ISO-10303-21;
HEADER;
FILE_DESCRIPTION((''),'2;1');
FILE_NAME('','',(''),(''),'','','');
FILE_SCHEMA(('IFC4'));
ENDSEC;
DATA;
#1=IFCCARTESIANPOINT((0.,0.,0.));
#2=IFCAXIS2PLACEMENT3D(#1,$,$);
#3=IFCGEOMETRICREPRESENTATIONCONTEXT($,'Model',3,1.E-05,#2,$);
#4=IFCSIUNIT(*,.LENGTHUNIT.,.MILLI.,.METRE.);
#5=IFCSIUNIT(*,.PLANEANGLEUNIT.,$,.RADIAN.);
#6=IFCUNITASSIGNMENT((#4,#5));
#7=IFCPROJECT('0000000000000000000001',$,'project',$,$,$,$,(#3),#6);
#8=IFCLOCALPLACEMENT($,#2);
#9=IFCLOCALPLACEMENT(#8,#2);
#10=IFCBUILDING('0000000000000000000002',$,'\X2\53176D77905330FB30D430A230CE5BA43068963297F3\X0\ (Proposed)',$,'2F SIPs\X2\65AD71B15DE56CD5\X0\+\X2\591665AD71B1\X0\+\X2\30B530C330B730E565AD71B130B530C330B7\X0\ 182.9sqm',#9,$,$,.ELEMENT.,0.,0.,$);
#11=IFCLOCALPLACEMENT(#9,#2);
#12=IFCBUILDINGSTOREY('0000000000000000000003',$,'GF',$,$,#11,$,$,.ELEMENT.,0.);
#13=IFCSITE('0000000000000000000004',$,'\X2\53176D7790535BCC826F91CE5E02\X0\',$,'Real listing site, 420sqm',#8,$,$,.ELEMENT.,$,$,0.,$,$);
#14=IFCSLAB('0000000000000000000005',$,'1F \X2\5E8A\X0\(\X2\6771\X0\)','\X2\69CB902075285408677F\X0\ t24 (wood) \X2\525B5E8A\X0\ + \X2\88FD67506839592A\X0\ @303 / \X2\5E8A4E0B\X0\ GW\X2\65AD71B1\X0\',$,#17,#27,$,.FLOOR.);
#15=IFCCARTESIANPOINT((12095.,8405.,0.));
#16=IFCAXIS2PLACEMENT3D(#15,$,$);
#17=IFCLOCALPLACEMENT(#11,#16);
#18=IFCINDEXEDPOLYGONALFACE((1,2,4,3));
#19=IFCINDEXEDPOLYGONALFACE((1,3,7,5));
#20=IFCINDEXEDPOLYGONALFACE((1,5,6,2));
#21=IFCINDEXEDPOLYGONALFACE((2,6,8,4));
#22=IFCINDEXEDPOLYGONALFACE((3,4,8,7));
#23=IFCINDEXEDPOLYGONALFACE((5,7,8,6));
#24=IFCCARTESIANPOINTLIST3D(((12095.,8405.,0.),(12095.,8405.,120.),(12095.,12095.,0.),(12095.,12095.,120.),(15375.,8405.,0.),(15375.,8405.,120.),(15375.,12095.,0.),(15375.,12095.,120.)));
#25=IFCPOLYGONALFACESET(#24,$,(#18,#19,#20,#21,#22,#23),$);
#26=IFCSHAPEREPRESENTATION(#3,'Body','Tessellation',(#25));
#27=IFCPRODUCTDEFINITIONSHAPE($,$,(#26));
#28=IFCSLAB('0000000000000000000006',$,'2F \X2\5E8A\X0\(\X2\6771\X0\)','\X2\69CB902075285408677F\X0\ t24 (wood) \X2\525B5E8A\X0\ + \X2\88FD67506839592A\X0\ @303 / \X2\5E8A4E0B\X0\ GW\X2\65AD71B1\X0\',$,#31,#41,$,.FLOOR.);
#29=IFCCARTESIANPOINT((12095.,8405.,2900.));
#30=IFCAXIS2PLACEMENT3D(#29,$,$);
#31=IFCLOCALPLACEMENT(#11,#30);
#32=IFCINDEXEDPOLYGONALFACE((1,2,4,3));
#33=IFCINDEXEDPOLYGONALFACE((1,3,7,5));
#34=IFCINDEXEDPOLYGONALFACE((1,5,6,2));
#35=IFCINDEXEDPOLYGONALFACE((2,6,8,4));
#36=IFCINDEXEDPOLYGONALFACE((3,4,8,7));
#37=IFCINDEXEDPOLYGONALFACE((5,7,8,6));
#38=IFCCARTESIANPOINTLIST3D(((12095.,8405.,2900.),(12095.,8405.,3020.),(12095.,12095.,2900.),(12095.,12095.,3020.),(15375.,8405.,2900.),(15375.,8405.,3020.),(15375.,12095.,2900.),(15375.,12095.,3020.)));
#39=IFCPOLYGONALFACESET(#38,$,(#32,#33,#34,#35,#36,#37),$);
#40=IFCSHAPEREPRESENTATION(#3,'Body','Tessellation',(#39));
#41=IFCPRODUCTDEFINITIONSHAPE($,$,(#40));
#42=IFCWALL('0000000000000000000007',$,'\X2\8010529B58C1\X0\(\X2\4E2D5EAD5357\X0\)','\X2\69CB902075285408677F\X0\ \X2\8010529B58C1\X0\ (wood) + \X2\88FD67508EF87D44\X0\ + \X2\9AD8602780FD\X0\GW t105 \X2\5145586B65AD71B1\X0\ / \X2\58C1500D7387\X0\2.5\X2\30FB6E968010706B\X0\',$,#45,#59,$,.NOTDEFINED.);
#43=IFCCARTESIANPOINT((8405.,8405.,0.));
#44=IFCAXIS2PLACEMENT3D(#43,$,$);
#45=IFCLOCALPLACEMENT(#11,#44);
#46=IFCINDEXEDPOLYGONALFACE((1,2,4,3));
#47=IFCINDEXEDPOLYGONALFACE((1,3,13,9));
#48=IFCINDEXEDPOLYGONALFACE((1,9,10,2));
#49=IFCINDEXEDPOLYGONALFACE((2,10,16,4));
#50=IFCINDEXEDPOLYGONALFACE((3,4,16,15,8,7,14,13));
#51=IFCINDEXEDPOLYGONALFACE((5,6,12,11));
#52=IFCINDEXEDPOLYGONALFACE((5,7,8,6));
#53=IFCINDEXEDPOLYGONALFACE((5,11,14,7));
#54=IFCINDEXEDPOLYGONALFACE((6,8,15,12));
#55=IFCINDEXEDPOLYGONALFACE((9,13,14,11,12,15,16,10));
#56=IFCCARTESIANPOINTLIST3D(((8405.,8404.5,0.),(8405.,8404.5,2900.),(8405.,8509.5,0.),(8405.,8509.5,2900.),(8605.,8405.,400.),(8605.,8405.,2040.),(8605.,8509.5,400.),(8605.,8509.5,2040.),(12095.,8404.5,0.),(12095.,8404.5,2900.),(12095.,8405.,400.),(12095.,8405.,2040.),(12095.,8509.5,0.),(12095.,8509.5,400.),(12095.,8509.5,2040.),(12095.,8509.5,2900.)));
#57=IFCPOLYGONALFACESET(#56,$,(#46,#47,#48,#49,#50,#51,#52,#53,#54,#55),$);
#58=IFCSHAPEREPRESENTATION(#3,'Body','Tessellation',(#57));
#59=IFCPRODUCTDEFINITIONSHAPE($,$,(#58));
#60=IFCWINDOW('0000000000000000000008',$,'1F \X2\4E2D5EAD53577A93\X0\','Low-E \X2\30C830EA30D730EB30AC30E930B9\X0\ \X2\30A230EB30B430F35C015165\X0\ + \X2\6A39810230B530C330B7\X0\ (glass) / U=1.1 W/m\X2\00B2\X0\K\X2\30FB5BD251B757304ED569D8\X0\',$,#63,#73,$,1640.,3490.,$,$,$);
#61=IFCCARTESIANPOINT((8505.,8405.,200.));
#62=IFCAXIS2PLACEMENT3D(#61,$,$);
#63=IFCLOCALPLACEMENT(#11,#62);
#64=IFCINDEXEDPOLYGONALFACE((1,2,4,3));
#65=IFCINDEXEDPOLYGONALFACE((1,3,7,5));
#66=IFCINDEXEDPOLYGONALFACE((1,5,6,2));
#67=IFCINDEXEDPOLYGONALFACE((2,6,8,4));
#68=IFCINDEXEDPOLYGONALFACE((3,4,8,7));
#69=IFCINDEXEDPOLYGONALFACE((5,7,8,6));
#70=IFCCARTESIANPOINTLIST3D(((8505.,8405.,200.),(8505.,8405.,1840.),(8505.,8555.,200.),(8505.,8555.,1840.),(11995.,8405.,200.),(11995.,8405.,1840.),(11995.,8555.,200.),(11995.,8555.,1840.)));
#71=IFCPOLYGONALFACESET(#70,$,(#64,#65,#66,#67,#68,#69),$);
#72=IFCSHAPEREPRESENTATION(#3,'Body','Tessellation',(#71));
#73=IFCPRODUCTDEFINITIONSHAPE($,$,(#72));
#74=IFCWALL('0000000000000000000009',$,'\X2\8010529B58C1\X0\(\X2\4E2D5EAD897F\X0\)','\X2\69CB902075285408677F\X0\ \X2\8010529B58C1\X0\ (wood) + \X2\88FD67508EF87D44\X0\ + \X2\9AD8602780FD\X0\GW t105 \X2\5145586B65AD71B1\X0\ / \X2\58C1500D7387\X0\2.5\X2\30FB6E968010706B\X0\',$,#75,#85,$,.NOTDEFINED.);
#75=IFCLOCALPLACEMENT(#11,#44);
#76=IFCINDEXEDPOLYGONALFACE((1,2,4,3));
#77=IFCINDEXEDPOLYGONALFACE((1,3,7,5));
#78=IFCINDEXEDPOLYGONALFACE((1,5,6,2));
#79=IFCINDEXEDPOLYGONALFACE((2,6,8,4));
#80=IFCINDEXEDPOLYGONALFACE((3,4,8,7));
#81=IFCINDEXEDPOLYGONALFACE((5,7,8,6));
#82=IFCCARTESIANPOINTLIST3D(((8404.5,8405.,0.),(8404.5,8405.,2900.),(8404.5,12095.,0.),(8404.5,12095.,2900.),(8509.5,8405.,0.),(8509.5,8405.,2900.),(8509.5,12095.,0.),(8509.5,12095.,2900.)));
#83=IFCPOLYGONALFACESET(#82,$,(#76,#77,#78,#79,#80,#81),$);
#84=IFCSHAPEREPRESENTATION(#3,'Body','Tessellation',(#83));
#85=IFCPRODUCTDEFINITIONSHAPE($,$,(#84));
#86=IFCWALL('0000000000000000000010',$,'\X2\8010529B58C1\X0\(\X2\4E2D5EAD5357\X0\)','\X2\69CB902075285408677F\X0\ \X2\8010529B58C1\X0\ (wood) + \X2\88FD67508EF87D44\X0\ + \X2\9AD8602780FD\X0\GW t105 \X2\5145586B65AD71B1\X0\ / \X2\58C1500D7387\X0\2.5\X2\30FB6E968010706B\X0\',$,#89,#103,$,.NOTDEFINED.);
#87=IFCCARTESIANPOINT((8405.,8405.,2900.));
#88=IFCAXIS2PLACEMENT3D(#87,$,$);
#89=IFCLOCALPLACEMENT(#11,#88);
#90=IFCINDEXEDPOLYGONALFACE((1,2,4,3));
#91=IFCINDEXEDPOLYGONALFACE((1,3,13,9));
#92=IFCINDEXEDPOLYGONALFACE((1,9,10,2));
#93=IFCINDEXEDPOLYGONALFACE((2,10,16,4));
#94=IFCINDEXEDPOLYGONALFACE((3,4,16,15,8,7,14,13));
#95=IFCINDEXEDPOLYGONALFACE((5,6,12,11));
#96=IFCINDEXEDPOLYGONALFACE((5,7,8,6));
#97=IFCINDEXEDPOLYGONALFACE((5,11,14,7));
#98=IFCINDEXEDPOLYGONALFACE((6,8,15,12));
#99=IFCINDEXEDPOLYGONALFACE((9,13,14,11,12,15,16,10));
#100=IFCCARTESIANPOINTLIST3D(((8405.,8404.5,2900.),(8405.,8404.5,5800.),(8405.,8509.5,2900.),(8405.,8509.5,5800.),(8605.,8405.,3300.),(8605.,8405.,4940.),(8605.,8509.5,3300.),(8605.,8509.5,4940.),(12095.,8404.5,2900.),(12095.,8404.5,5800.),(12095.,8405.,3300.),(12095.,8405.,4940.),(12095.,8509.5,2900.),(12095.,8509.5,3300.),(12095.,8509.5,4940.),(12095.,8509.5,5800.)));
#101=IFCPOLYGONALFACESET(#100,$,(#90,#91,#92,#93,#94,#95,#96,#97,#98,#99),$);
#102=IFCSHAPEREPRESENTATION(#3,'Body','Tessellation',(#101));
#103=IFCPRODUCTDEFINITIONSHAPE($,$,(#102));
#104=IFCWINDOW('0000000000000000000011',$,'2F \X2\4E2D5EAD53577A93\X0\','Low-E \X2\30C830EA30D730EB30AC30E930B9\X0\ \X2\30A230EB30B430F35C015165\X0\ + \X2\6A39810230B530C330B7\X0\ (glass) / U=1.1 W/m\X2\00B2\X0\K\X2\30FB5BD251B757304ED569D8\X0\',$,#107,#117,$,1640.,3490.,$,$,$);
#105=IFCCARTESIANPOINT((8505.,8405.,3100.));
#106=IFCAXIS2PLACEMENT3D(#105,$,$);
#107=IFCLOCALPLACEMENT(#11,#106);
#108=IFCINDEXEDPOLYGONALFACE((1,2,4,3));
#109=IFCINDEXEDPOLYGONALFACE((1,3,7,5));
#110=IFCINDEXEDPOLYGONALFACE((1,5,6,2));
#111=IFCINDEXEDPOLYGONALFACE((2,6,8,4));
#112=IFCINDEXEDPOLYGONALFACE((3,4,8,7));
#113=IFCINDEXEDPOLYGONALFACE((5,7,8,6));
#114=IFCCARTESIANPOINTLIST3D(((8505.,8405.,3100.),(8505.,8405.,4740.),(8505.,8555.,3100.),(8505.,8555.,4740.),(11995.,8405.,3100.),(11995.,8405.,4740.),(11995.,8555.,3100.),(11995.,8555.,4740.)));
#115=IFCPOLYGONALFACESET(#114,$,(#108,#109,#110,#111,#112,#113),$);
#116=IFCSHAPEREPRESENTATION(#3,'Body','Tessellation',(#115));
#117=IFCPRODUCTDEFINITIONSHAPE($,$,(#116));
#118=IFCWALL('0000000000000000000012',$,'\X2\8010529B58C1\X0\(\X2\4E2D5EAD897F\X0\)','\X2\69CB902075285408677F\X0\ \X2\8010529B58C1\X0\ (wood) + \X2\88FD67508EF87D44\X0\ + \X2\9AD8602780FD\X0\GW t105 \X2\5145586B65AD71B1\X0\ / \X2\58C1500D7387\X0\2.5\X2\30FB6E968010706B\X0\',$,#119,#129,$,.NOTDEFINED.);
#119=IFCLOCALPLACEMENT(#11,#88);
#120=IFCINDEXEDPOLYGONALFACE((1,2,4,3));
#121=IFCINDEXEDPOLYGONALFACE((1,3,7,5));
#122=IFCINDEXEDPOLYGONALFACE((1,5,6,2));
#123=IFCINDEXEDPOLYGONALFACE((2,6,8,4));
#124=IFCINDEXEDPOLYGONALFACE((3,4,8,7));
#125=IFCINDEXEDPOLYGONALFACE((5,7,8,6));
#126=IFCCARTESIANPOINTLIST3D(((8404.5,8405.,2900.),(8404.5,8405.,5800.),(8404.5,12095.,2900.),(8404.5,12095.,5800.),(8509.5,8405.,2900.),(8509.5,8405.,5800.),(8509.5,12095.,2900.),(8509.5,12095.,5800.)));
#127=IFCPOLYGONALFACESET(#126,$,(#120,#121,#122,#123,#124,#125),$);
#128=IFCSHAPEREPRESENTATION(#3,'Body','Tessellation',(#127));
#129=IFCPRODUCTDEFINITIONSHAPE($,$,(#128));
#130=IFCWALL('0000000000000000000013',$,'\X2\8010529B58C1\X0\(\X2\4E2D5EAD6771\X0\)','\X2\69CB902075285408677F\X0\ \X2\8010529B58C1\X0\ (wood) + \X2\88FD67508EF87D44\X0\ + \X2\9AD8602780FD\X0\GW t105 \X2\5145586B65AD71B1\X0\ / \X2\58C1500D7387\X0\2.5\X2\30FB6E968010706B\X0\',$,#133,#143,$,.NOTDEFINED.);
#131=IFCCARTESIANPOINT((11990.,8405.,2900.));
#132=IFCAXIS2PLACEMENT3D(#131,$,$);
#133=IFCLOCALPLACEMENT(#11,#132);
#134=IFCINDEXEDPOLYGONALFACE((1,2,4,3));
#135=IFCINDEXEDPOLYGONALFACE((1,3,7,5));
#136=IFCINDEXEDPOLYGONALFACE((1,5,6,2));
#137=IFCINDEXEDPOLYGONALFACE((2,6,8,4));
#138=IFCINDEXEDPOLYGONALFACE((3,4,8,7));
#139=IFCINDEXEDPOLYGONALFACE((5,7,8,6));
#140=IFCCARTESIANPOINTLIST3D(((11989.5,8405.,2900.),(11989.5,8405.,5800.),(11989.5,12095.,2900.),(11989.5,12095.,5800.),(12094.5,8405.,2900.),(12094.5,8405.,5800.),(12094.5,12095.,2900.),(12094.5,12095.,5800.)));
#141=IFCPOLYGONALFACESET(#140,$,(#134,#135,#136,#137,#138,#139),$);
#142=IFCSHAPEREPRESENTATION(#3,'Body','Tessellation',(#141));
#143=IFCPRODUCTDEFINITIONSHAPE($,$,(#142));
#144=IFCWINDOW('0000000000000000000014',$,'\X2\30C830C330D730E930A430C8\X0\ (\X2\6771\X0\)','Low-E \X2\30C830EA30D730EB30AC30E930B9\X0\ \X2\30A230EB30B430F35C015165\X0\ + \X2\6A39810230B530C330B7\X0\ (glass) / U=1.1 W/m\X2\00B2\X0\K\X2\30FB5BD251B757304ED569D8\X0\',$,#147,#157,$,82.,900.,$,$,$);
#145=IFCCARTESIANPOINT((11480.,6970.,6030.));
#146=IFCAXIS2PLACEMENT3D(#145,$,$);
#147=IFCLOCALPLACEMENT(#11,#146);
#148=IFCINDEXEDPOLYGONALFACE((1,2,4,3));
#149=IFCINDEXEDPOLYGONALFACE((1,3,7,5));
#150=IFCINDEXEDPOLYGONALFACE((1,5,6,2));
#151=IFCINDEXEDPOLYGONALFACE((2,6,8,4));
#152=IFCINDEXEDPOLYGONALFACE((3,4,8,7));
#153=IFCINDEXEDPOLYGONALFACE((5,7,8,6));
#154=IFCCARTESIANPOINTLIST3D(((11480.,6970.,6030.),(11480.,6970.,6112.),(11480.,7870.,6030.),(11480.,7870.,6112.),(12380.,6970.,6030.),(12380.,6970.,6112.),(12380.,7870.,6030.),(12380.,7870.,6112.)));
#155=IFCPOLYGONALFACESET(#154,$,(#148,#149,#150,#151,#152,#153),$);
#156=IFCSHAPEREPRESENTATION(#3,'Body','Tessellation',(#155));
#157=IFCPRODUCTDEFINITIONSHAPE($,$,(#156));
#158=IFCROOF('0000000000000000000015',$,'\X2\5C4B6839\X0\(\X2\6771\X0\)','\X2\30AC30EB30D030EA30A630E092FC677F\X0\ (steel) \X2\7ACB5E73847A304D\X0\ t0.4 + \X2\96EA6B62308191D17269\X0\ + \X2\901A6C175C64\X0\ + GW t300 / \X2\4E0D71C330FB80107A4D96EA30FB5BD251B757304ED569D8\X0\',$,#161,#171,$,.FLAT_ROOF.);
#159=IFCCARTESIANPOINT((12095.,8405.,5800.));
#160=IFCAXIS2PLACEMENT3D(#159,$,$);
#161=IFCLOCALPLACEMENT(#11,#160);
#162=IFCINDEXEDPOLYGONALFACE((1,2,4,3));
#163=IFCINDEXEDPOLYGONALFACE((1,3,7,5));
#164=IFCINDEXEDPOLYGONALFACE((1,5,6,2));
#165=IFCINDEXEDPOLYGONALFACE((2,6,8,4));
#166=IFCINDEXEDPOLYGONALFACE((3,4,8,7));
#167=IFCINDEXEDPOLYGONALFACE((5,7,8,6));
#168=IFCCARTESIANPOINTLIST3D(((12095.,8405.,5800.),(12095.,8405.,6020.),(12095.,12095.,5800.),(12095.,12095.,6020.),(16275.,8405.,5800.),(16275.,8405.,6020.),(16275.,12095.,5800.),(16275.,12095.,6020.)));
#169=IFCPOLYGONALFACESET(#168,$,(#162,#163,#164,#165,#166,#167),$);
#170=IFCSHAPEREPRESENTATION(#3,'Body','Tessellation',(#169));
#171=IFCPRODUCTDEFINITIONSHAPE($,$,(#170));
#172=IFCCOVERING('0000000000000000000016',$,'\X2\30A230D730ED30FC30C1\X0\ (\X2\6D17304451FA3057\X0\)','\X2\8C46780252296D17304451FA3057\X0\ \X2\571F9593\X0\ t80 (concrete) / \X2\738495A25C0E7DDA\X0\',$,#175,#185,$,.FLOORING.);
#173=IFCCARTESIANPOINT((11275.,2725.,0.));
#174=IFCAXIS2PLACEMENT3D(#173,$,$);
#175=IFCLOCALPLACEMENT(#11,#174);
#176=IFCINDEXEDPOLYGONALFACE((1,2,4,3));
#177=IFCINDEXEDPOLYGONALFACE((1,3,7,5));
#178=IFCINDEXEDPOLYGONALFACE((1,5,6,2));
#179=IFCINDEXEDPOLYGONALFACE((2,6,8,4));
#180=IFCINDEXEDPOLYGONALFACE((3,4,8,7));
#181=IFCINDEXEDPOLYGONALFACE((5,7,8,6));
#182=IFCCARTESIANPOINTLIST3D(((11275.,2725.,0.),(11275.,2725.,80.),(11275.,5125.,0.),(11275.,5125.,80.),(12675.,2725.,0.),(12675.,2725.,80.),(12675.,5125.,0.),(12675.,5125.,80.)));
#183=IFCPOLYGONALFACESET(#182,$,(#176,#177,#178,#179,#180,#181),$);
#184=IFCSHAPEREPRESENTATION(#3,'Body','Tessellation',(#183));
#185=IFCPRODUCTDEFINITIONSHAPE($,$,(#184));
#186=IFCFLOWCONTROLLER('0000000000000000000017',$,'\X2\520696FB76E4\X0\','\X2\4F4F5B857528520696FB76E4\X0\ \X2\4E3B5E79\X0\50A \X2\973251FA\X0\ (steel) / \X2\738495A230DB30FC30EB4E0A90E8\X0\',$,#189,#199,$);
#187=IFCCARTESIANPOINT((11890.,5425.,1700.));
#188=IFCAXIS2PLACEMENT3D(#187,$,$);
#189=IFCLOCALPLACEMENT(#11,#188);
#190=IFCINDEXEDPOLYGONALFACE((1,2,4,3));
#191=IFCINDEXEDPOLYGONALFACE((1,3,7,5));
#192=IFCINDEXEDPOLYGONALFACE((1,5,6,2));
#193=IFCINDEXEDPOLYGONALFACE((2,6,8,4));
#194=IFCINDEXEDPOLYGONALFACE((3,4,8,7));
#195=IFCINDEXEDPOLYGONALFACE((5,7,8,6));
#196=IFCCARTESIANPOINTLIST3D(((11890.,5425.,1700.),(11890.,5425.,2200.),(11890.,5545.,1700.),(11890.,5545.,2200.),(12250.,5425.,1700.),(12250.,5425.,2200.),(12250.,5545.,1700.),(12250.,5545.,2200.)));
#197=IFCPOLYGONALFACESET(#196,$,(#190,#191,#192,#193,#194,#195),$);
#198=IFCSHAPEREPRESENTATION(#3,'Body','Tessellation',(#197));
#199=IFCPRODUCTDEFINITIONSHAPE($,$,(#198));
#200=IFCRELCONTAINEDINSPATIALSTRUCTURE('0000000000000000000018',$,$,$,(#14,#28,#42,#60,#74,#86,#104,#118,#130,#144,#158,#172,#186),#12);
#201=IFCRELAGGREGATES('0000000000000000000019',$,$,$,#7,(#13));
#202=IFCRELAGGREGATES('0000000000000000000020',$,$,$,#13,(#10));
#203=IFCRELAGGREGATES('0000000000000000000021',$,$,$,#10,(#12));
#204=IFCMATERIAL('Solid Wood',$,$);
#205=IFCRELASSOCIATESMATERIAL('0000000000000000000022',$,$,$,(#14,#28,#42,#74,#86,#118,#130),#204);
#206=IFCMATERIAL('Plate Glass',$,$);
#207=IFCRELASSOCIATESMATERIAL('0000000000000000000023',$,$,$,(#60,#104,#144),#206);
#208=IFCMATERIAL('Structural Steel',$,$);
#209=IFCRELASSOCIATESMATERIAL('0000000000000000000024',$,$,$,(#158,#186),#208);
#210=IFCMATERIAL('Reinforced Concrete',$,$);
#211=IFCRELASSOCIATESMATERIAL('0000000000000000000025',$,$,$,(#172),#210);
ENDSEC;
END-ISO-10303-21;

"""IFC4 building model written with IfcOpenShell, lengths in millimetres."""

from ifc_helpers import new_model, si_unit, frame, frame_2d, origin, place, context, project, spatial, rectangle, extrude, material, element, fill, save


model = new_model("IFC4")

# Units and contexts
model_context = context("Model", 3, precision=1e-05, world=origin())
ifc_project = project(units=[si_unit("LENGTHUNIT", "METRE", prefix="MILLI"), si_unit("PLANEANGLEUNIT", "RADIAN")], contexts=[model_context])

# Site, building, storey
site_placement = place(None, origin())
site = spatial("IfcSite", under=ifc_project, at=site_placement, Name="北海道富良野市", ObjectType="Real listing site, 420sqm", CompositionType="ELEMENT", RefElevation=0.0)
building_placement = place(site_placement, origin())
building = spatial("IfcBuilding", under=site, at=building_placement, Name="北海道・ピアノ室と防音 (Proposed)", ObjectType="2F SIPs断熱工法+外断熱+サッシュ断熱サッシ 182.9sqm", CompositionType="ELEMENT", ElevationOfRefHeight=0.0, ElevationOfTerrain=0.0)
storey_placement = place(building_placement, origin())
storey = spatial("IfcBuildingStorey", under=building, at=storey_placement, Name="GF", CompositionType="ELEMENT", Elevation=0.0)

# Shared definitions
ifc_material_1 = material(Name="Solid Wood")

# Slabs
slab_1_placement = place(storey_placement, frame((12095.0, 8405.0, 0.0)))
element("IfcSlab", 1, at=slab_1_placement, inside=storey, material=ifc_material_1, Name="1F 床(東)", Description="構造用合板 t24 (wood) 剛床 + 製材根太 @303 / 床下 GW断熱", PredefinedType="FLOOR", context=model_context, shape_type="SweptSolid", body=[
    extrude(rectangle(XDim=3280.0, YDim=3690.0, at=frame_2d((1640.0, 1845.0))), frame((12095.0, 8405.0, 0.0)), (0.0, 0.0, 1.0), 120.0),
])
slab_2_placement = place(storey_placement, frame((12095.0, 8405.0, 2900.0)))
element("IfcSlab", 2, at=slab_2_placement, inside=storey, material=ifc_material_1, Name="2F 床(東)", Description="構造用合板 t24 (wood) 剛床 + 製材根太 @303 / 床下 GW断熱", PredefinedType="FLOOR", context=model_context, shape_type="SweptSolid", body=[
    extrude(rectangle(XDim=3280.0, YDim=3690.0, at=frame_2d((1640.0, 1845.0))), frame((12095.0, 8405.0, 2900.0)), (0.0, 0.0, 1.0), 120.0),
])

# Wall, opening, window
wall_1_placement = place(storey_placement, frame((8405.0, 8405.0, 0.0)))
wall_1 = element("IfcWall", 3, at=wall_1_placement, inside=storey, material=ifc_material_1, Name="耐力壁(中庭南)", Description="構造用合板 耐力壁 (wood) + 製材軸組 + 高性能GW t105 充填断熱 / 壁倍率2.5・準耐火", PredefinedType="NOTDEFINED", context=model_context, shape_type="SweptSolid", body=[
    extrude(rectangle(XDim=3690.0, YDim=105.0, at=frame_2d((1845.0, 52.0))), frame((8405.0, 8405.0, 0.0)), (0.0, 0.0, 1.0), 2900.0),
])
opening_1_placement = place(storey_placement, frame((8505.0, 8405.0, 200.0)))
opening_1 = element("IfcOpeningElement", 4, at=opening_1_placement, cuts=wall_1, PredefinedType="NOTDEFINED", context=model_context, shape_type="SweptSolid", body=[
    extrude(rectangle(XDim=3490.0, YDim=150.0, at=frame_2d((1745.0, 75.0))), frame((8505.0, 8405.0, 200.0)), (0.0, 0.0, 1.0), 1640.0),
])
ifc_material_2 = material(Name="Plate Glass")
window_1_placement = place(storey_placement, frame((8505.0, 8405.0, 200.0)))
window_1 = element("IfcWindow", 5, at=window_1_placement, inside=storey, material=ifc_material_2, Name="1F 中庭南窓", Description="Low-E トリプルガラス アルゴン封入 + 樹脂サッシ (glass) / U=1.1 W/m²K・寒冷地仕様", OverallHeight=1640.0, OverallWidth=3490.0, context=model_context, shape_type="SweptSolid", body=[
    extrude(rectangle(XDim=3490.0, YDim=150.0, at=frame_2d((1745.0, 75.0))), frame((8505.0, 8405.0, 200.0)), (0.0, 0.0, 1.0), 1640.0),
])
fill(opening_1, window_1)

# Wall
wall_2_placement = place(storey_placement, frame((8405.0, 8405.0, 0.0)))
element("IfcWall", 6, at=wall_2_placement, inside=storey, material=ifc_material_1, Name="耐力壁(中庭西)", Description="構造用合板 耐力壁 (wood) + 製材軸組 + 高性能GW t105 充填断熱 / 壁倍率2.5・準耐火", PredefinedType="NOTDEFINED", context=model_context, shape_type="SweptSolid", body=[
    extrude(rectangle(XDim=105.0, YDim=3690.0, at=frame_2d((52.0, 1845.0))), frame((8405.0, 8405.0, 0.0)), (0.0, 0.0, 1.0), 2900.0),
])

# Wall, opening, window
wall_3_placement = place(storey_placement, frame((8405.0, 8405.0, 2900.0)))
wall_3 = element("IfcWall", 7, at=wall_3_placement, inside=storey, material=ifc_material_1, Name="耐力壁(中庭南)", Description="構造用合板 耐力壁 (wood) + 製材軸組 + 高性能GW t105 充填断熱 / 壁倍率2.5・準耐火", PredefinedType="NOTDEFINED", context=model_context, shape_type="SweptSolid", body=[
    extrude(rectangle(XDim=3690.0, YDim=105.0, at=frame_2d((1845.0, 52.0))), frame((8405.0, 8405.0, 2900.0)), (0.0, 0.0, 1.0), 2900.0),
])
opening_2_placement = place(storey_placement, frame((8505.0, 8405.0, 3100.0)))
opening_2 = element("IfcOpeningElement", 8, at=opening_2_placement, cuts=wall_3, PredefinedType="NOTDEFINED", context=model_context, shape_type="SweptSolid", body=[
    extrude(rectangle(XDim=3490.0, YDim=150.0, at=frame_2d((1745.0, 75.0))), frame((8505.0, 8405.0, 3100.0)), (0.0, 0.0, 1.0), 1640.0),
])
window_2_placement = place(storey_placement, frame((8505.0, 8405.0, 3100.0)))
window_2 = element("IfcWindow", 9, at=window_2_placement, inside=storey, material=ifc_material_2, Name="2F 中庭南窓", Description="Low-E トリプルガラス アルゴン封入 + 樹脂サッシ (glass) / U=1.1 W/m²K・寒冷地仕様", OverallHeight=1640.0, OverallWidth=3490.0, context=model_context, shape_type="SweptSolid", body=[
    extrude(rectangle(XDim=3490.0, YDim=150.0, at=frame_2d((1745.0, 75.0))), frame((8505.0, 8405.0, 3100.0)), (0.0, 0.0, 1.0), 1640.0),
])
fill(opening_2, window_2)

# Walls
wall_4_placement = place(storey_placement, frame((8405.0, 8405.0, 2900.0)))
element("IfcWall", 10, at=wall_4_placement, inside=storey, material=ifc_material_1, Name="耐力壁(中庭西)", Description="構造用合板 耐力壁 (wood) + 製材軸組 + 高性能GW t105 充填断熱 / 壁倍率2.5・準耐火", PredefinedType="NOTDEFINED", context=model_context, shape_type="SweptSolid", body=[
    extrude(rectangle(XDim=105.0, YDim=3690.0, at=frame_2d((52.0, 1845.0))), frame((8405.0, 8405.0, 2900.0)), (0.0, 0.0, 1.0), 2900.0),
])
wall_5_placement = place(storey_placement, frame((11990.0, 8405.0, 2900.0)))
element("IfcWall", 11, at=wall_5_placement, inside=storey, material=ifc_material_1, Name="耐力壁(中庭東)", Description="構造用合板 耐力壁 (wood) + 製材軸組 + 高性能GW t105 充填断熱 / 壁倍率2.5・準耐火", PredefinedType="NOTDEFINED", context=model_context, shape_type="SweptSolid", body=[
    extrude(rectangle(XDim=105.0, YDim=3690.0, at=frame_2d((52.0, 1845.0))), frame((11990.0, 8405.0, 2900.0)), (0.0, 0.0, 1.0), 2900.0),
])

# Window
window_3_placement = place(storey_placement, frame((11480.0, 6970.0, 6030.0)))
element("IfcWindow", 12, at=window_3_placement, inside=storey, material=ifc_material_2, Name="トップライト (東)", Description="Low-E トリプルガラス アルゴン封入 + 樹脂サッシ (glass) / U=1.1 W/m²K・寒冷地仕様", OverallHeight=82.0, OverallWidth=900.0, context=model_context, shape_type="SweptSolid", body=[
    extrude(rectangle(XDim=900.0, YDim=900.0, at=frame_2d((450.0, 450.0))), frame((11480.0, 6970.0, 6030.0)), (0.0, 0.0, 1.0), 82.0),
])

# Roof
ifc_material_3 = material(Name="Structural Steel")
for number, where, name in (
    (13, (12095.0, 8405.0, 5800.0), "屋根(東)"),
):
    element("IfcRoof", number, at=place(storey_placement, frame(where)), inside=storey, material=ifc_material_3, Name=name, Description="ガルバリウム鋼板 (steel) 立平葺き t0.4 + 雪止め金物 + 通気層 + GW t300 / 不燃・耐積雪・寒冷地仕様", PredefinedType="FLAT_ROOF", context=model_context, shape_type="SweptSolid", body=[
        extrude(rectangle(XDim=4180.0, YDim=3690.0, at=frame_2d((2090.0, 1845.0))), frame((12095.0, 8405.0, 5800.0)), (0.0, 0.0, 1.0), 220.0),
    ])

# Covering
ifc_material_4 = material(Name="Reinforced Concrete")
covering_placement = place(storey_placement, frame((11275.0, 2725.0, 0.0)))
element("IfcCovering", 14, at=covering_placement, inside=storey, material=ifc_material_4, Name="アプローチ (洗い出し)", Description="豆砂利洗い出し 土間 t80 (concrete) / 玄関導線", PredefinedType="FLOORING", context=model_context, shape_type="SweptSolid", body=[
    extrude(rectangle(XDim=1400.0, YDim=2400.0, at=frame_2d((700.0, 1200.0))), frame((11275.0, 2725.0, 0.0)), (0.0, 0.0, 1.0), 80.0),
])

# Flow controller
flow_controller_placement = place(storey_placement, frame((11890.0, 5425.0, 1700.0)))
element("IfcFlowController", 15, at=flow_controller_placement, inside=storey, material=ifc_material_3, Name="分電盤", Description="住宅用分電盤 主幹50A 露出 (steel) / 玄関ホール上部", context=model_context, shape_type="SweptSolid", body=[
    extrude(rectangle(XDim=360.0, YDim=120.0, at=frame_2d((180.0, 60.0))), frame((11890.0, 5425.0, 1700.0)), (0.0, 0.0, 1.0), 500.0),
])

save(model, "model.ifc")
